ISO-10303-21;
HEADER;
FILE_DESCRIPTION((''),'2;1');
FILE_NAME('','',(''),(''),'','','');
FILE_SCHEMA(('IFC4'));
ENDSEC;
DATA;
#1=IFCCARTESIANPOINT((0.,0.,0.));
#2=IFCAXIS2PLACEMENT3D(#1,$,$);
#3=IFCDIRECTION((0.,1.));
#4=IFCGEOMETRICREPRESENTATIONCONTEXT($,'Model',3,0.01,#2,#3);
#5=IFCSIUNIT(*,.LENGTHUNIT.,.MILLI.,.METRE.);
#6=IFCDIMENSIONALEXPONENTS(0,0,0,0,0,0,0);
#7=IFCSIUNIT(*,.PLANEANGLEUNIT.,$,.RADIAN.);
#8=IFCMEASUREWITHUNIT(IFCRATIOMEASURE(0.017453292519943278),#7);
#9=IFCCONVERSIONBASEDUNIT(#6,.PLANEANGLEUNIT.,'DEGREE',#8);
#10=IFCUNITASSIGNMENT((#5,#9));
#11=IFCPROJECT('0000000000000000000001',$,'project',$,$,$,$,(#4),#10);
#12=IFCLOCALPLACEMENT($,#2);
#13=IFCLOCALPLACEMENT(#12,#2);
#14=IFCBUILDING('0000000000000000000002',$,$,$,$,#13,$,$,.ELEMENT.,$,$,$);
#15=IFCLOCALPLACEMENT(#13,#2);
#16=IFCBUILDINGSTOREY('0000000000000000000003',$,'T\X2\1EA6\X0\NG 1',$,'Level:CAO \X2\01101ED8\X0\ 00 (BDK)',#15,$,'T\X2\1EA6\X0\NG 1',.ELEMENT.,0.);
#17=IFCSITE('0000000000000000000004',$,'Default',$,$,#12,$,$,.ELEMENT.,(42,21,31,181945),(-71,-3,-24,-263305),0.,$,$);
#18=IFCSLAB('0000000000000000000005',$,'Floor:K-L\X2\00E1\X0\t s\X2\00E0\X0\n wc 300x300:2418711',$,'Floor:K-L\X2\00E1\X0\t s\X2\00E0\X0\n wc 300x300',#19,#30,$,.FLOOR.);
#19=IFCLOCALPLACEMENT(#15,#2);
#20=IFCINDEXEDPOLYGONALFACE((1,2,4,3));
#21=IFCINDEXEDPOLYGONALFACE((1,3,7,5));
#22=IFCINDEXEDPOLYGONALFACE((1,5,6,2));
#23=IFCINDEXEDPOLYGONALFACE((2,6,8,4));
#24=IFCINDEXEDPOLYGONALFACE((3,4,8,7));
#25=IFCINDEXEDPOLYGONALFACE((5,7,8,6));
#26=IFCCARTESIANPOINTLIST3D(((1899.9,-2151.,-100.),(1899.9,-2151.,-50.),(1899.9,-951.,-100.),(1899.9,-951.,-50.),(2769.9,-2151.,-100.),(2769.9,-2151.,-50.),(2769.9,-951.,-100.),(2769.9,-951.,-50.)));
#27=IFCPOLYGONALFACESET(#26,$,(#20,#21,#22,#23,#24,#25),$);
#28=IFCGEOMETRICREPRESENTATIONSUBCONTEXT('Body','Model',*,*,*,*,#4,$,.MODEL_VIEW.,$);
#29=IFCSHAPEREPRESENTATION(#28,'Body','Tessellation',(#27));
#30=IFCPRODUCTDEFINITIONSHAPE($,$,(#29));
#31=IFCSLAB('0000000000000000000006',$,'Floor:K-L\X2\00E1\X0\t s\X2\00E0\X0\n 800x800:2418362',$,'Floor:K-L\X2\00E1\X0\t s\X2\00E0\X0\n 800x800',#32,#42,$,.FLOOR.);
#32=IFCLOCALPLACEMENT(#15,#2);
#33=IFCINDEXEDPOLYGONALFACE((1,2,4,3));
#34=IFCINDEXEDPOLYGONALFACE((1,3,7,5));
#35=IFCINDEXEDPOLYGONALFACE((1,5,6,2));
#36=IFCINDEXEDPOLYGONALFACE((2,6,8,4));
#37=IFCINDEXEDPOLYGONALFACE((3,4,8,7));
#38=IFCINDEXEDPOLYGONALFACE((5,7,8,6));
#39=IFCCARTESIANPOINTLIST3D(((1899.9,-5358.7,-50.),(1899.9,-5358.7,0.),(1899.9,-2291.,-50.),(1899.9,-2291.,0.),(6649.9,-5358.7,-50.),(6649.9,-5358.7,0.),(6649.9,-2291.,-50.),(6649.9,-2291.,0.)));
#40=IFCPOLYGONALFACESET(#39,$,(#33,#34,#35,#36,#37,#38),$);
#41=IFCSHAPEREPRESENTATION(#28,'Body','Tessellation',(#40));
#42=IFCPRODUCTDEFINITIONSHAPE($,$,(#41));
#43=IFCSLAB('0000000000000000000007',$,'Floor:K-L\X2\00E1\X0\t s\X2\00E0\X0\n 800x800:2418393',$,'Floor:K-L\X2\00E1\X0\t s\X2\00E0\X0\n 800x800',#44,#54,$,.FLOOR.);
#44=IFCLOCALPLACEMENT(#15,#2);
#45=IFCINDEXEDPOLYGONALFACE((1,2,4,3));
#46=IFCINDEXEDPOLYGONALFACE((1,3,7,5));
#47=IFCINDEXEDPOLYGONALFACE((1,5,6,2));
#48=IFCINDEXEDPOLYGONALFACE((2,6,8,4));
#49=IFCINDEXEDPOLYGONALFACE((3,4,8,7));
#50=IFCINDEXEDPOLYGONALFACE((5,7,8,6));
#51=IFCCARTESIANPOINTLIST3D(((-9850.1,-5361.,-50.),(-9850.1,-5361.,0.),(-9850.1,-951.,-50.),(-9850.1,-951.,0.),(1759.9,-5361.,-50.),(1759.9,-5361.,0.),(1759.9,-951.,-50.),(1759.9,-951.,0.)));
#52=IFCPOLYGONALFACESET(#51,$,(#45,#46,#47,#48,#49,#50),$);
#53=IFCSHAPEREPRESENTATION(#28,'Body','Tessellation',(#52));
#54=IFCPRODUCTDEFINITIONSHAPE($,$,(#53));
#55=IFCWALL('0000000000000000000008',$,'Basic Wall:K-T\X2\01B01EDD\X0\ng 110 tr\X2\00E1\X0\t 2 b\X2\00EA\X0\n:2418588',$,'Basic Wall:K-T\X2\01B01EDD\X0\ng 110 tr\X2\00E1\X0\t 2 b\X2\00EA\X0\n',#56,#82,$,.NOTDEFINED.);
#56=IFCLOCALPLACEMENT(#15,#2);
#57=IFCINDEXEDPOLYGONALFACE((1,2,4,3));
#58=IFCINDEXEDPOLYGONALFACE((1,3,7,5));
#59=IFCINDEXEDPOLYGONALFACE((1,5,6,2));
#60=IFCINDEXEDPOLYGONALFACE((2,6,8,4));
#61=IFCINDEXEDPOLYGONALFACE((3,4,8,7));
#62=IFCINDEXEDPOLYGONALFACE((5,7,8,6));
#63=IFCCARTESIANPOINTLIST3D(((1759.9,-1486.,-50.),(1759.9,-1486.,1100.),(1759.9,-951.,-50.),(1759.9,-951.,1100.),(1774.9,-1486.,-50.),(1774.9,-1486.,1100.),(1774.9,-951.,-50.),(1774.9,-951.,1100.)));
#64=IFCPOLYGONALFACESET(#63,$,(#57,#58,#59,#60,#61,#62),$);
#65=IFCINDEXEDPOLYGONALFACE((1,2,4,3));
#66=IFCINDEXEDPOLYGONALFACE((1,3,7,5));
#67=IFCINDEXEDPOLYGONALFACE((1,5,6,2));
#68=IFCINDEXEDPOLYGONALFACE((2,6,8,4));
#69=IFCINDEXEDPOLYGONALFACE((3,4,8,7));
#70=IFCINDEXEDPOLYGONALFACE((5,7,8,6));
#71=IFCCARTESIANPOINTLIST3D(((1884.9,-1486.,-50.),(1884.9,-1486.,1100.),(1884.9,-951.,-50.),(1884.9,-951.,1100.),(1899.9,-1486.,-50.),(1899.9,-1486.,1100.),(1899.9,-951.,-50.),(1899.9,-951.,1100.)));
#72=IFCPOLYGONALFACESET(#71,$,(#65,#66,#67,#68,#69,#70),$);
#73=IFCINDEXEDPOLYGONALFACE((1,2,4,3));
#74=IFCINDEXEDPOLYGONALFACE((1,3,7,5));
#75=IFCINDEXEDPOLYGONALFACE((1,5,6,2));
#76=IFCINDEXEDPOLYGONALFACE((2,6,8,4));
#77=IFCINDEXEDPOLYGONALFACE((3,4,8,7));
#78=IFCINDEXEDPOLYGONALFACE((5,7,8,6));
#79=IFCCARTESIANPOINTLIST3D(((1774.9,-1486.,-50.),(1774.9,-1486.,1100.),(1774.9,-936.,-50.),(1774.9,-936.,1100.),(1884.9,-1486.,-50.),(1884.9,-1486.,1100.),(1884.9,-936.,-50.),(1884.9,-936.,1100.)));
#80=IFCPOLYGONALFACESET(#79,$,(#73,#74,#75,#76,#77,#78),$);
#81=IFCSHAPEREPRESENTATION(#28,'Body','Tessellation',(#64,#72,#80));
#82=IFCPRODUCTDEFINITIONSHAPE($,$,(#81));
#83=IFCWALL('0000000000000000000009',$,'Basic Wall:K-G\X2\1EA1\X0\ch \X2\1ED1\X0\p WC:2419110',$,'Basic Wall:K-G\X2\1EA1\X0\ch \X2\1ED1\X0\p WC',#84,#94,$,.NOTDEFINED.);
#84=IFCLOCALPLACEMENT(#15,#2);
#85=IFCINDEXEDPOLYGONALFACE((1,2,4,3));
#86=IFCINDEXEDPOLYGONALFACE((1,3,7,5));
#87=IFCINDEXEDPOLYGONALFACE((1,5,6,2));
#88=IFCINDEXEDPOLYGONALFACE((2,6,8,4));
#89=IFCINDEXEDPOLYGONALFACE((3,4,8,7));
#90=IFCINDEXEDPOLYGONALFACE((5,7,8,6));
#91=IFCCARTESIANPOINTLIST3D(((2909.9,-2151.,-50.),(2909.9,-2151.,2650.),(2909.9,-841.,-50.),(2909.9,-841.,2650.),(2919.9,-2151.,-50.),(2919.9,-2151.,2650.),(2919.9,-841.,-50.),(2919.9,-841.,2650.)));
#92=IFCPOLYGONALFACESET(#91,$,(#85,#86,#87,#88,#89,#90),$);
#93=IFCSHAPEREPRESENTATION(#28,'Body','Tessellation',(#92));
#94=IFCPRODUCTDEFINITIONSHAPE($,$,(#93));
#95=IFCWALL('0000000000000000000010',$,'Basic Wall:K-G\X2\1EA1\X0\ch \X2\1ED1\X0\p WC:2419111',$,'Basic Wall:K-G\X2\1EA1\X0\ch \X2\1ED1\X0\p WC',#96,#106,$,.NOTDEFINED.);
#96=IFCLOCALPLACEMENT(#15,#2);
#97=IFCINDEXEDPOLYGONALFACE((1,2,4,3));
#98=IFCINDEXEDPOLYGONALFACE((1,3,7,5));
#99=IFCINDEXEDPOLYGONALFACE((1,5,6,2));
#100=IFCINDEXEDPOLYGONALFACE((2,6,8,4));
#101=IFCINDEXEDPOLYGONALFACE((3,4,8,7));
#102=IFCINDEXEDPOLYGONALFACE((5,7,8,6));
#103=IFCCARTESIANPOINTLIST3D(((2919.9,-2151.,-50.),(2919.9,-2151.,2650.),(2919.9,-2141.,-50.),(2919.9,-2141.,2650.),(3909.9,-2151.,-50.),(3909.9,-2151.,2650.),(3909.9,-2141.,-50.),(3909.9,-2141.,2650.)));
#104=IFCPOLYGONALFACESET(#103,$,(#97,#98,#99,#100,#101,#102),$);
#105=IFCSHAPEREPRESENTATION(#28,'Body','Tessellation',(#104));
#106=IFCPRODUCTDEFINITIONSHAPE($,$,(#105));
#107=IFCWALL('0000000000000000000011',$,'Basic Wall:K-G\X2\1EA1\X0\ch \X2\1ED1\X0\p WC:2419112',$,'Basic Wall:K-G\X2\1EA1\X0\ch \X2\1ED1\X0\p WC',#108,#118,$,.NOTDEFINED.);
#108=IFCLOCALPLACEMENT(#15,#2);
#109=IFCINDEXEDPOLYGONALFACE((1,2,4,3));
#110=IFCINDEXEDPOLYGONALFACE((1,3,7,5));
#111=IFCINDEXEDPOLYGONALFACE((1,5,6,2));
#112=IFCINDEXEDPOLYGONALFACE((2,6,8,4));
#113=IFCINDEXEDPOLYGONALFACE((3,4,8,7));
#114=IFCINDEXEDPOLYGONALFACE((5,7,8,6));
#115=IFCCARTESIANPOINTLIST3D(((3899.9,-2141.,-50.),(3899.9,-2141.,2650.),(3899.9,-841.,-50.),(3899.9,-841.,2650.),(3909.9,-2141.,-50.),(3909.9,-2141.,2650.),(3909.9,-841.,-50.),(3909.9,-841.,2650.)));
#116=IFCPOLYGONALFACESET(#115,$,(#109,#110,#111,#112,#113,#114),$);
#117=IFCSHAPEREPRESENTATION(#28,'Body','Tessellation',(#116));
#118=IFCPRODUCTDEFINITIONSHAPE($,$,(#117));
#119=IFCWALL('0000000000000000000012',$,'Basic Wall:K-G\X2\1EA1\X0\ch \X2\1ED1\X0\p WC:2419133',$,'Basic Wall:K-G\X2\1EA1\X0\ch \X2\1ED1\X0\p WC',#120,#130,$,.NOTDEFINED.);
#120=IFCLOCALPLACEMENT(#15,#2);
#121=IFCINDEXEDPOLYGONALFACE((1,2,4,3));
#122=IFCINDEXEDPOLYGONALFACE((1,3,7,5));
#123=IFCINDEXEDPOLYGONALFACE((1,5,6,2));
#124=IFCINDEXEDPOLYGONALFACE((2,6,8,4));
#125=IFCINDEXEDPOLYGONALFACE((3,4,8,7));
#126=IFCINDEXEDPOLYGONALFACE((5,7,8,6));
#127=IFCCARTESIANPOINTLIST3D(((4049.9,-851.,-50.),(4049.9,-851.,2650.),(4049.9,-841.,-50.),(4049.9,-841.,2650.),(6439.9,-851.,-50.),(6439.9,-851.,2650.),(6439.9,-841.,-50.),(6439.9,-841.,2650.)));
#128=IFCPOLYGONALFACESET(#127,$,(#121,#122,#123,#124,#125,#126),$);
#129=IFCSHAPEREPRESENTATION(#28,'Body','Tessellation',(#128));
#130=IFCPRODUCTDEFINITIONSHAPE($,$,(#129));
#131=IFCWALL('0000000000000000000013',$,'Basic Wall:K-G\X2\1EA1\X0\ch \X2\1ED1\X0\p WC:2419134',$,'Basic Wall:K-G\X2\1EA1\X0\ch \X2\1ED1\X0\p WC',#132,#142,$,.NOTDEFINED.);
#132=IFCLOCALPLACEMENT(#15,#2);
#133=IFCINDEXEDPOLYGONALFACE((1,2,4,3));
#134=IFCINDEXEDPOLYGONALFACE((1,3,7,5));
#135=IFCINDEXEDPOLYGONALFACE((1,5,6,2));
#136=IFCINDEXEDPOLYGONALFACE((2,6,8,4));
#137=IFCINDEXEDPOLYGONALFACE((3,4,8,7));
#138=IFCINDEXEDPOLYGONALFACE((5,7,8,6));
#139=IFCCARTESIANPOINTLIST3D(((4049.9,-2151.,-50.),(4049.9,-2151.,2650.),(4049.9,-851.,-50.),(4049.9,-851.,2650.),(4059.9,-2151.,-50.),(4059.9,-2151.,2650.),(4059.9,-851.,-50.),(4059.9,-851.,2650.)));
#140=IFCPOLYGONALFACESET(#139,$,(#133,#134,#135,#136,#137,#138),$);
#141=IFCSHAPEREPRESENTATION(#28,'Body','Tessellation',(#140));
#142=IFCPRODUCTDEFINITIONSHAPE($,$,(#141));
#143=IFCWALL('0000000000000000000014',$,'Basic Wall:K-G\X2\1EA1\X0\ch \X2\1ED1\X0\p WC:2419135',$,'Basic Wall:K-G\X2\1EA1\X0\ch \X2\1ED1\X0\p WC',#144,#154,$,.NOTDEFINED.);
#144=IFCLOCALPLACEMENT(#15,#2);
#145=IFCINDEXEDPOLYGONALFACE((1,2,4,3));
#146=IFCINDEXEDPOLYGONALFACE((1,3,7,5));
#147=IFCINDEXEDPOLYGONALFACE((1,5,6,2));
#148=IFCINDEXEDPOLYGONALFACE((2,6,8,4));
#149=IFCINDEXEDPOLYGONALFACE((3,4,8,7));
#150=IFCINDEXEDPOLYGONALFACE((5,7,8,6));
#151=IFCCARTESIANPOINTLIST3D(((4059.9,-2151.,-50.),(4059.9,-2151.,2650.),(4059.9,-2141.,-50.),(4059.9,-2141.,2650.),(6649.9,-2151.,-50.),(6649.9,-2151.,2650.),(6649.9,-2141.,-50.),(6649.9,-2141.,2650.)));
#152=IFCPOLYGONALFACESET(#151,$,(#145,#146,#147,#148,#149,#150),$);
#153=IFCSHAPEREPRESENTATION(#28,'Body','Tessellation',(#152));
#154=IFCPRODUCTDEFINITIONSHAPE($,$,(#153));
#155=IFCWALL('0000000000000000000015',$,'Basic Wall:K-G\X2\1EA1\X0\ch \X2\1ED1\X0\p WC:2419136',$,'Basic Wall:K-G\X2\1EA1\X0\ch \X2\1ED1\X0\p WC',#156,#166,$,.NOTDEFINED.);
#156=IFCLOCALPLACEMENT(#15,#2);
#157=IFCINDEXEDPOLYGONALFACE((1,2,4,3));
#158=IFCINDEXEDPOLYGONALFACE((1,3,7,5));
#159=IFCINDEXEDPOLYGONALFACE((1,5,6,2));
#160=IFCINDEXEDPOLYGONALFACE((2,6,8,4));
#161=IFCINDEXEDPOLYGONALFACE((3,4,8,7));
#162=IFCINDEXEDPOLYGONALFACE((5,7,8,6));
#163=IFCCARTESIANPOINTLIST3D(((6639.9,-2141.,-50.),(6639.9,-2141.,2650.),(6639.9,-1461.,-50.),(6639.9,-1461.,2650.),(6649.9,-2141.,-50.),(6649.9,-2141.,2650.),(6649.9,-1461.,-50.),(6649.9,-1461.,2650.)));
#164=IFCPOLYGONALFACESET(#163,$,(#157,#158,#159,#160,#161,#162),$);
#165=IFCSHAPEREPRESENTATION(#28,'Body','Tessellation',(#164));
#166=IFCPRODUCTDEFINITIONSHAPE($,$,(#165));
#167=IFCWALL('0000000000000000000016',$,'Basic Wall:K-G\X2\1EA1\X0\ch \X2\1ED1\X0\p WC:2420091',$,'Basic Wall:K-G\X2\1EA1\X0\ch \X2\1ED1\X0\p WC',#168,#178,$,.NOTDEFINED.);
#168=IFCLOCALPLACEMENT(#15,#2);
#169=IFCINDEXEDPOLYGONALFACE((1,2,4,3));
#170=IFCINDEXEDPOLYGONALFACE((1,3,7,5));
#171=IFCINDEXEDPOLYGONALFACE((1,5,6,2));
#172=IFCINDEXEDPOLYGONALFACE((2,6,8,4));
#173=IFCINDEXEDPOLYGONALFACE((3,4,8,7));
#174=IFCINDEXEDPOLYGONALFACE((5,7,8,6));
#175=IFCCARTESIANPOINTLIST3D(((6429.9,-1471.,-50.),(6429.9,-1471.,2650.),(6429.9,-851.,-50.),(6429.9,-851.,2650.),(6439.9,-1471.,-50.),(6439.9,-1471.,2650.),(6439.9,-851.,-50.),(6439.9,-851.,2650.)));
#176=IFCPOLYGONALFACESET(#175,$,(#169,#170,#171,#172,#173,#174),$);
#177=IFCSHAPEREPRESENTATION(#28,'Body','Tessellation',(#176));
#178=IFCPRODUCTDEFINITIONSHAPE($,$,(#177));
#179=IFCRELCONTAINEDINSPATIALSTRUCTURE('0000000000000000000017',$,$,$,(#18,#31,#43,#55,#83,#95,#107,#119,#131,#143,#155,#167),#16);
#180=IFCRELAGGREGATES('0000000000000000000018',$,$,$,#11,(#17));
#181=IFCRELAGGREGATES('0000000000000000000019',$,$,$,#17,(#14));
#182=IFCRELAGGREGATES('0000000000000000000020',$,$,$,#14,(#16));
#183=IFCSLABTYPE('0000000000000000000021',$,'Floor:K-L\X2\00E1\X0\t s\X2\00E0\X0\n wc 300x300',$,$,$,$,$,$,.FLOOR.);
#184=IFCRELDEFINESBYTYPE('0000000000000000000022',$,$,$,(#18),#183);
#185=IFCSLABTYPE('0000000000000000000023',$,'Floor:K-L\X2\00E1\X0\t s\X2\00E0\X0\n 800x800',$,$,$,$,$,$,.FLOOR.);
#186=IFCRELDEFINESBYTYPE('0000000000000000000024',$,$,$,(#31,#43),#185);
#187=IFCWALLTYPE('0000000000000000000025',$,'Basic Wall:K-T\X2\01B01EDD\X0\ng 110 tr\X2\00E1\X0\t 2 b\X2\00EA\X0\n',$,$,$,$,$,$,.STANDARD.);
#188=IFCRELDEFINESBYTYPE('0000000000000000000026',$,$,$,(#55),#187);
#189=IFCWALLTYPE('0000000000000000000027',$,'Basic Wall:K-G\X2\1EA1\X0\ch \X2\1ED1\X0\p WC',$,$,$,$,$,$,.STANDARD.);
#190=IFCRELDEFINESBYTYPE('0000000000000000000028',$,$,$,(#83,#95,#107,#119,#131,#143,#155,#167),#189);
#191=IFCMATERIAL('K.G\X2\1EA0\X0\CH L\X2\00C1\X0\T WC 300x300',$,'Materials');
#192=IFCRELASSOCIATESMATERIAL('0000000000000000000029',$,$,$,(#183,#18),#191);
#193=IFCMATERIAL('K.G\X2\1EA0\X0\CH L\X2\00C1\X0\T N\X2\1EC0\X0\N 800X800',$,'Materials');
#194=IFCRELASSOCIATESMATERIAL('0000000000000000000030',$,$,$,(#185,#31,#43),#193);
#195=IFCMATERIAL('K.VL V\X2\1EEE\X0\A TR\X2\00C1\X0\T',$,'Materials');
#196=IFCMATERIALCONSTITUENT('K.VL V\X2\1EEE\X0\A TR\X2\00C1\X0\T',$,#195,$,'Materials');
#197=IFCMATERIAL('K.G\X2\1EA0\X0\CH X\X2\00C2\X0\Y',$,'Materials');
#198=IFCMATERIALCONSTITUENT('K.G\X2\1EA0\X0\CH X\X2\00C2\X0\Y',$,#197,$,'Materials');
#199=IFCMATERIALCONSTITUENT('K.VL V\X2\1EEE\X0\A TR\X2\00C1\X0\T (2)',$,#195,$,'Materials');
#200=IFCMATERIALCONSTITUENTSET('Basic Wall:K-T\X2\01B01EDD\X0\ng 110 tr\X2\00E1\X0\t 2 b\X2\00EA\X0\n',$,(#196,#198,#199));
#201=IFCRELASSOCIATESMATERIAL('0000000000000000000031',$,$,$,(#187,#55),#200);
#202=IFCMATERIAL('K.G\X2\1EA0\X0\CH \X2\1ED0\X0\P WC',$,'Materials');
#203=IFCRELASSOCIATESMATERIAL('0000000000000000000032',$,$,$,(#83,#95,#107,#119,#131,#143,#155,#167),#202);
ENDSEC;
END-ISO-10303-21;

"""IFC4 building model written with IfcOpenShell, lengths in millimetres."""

from ifc_helpers import new_model, entity, si_unit, converted_unit, direction, frame, origin, place, context, subcontext, project, spatial, indexed_curve, outline, extrude, material, constituent, constituent_set, type_object, element, save


model = new_model("IFC4")

# Units and contexts
model_context = context("Model", 3, precision=0.01, world=origin(), true_north=direction((0.0, 1.0)))
body_context = subcontext(model_context, "Body", "Model", "MODEL_VIEW")
ifc_project = project(units=[si_unit("LENGTHUNIT", "METRE", prefix="MILLI"), converted_unit("PLANEANGLEUNIT", "DEGREE", entity("IfcRatioMeasure", 0.017453292519943278), si_unit("PLANEANGLEUNIT", "RADIAN"), dimensions=[0, 0, 0, 0, 0, 0, 0])], contexts=[model_context])

# Site, building, storey
site_placement = place(None, origin())
site = spatial("IfcSite", under=ifc_project, at=site_placement, Name="Default", CompositionType="ELEMENT", RefLatitude=(42, 21, 31, 181945), RefLongitude=(-71, -3, -24, -263305), RefElevation=0.0)
building_placement = place(site_placement, origin())
building = spatial("IfcBuilding", under=site, at=building_placement, CompositionType="ELEMENT")
storey_placement = place(building_placement, origin())
storey = spatial("IfcBuildingStorey", under=building, at=storey_placement, Name="TẦNG 1", ObjectType="Level:CAO ĐỘ 00 (BDK)", LongName="TẦNG 1", CompositionType="ELEMENT", Elevation=0.0)

# Slabs
ifc_material_1 = material(Name="K.GẠCH LÁT WC 300x300", Category="Materials")
slab_type_1 = type_object("IfcSlabType", Name="Floor:K-Lát sàn wc 300x300", PredefinedType="FLOOR", material=ifc_material_1)
slab_1_placement = place(storey_placement, origin())
element("IfcSlab", 1, at=slab_1_placement, inside=storey, type_object=slab_type_1, material=ifc_material_1, Name="Floor:K-Lát sàn wc 300x300:2418711", ObjectType="Floor:K-Lát sàn wc 300x300", PredefinedType="FLOOR", context=body_context, shape_type="SweptSolid", body=[
    extrude(outline(indexed_curve([(-600.0, -435.0), (600.0, -435.0), (600.0, 435.0), (-600.0, 435.0), (-600.0, -435.0)], self_intersect=False)), frame((2334.9, -1551.0, -50.0), z_axis=(0.0, 0.0, -1.0), x_axis=(0.0, 1.0, 0.0)), (0.0, 0.0, 1.0), 50.0),
])
ifc_material_2 = material(Name="K.GẠCH LÁT NỀN 800X800", Category="Materials")
slab_type_2 = type_object("IfcSlabType", Name="Floor:K-Lát sàn 800x800", PredefinedType="FLOOR", material=ifc_material_2)
slab_2_placement = place(storey_placement, origin())
element("IfcSlab", 2, at=slab_2_placement, inside=storey, type_object=slab_type_2, material=ifc_material_2, Name="Floor:K-Lát sàn 800x800:2418362", ObjectType="Floor:K-Lát sàn 800x800", PredefinedType="FLOOR", context=body_context, shape_type="SweptSolid", body=[
    extrude(outline(indexed_curve([(-1533.8, -2375.0), (1533.8, -2375.0), (1533.8, 2375.0), (-1533.8, 2375.0), (-1533.8, -2375.0)], self_intersect=False)), frame((4274.9, -3824.8, 0.0), z_axis=(0.0, 0.0, -1.0), x_axis=(0.0, 1.0, 0.0)), (0.0, 0.0, 1.0), 50.0),
])
slab_3_placement = place(storey_placement, origin())
element("IfcSlab", 3, at=slab_3_placement, inside=storey, type_object=slab_type_2, material=ifc_material_2, Name="Floor:K-Lát sàn 800x800:2418393", ObjectType="Floor:K-Lát sàn 800x800", PredefinedType="FLOOR", context=body_context, shape_type="SweptSolid", body=[
    extrude(outline(indexed_curve([(-2205.0, -5805.0), (2205.0, -5805.0), (2205.0, 5805.0), (-2205.0, 5805.0), (-2205.0, -5805.0)], self_intersect=False)), frame((-4045.1, -3156.0, 0.0), z_axis=(0.0, 0.0, -1.0), x_axis=(0.0, 1.0, 0.0)), (0.0, 0.0, 1.0), 50.0),
])

# Shared definitions
ifc_material_3 = material(Name="K.VL VỮA TRÁT", Category="Materials")
ifc_constituent_1 = constituent(ifc_material_3, Name="K.VL VỮA TRÁT", Category="Materials")
ifc_material_4 = material(Name="K.GẠCH XÂY", Category="Materials")
ifc_constituent_2 = constituent(ifc_material_4, Name="K.GẠCH XÂY", Category="Materials")
ifc_constituent_3 = constituent(ifc_material_3, Name="K.VL VỮA TRÁT (2)", Category="Materials")
ifc_constituent_set_1 = constituent_set(constituents=[ifc_constituent_1, ifc_constituent_2, ifc_constituent_3], Name="Basic Wall:K-Tường 110 trát 2 bên")
wall_type_1 = type_object("IfcWallType", Name="Basic Wall:K-Tường 110 trát 2 bên", PredefinedType="STANDARD", material=ifc_constituent_set_1)

# Walls
wall_1_placement = place(storey_placement, frame((1829.9, -951.0, -50.0), z_axis=(0.0, 0.0, 1.0), x_axis=(0.0, -1.0, 0.0)))
element("IfcWall", 4, at=wall_1_placement, inside=storey, type_object=wall_type_1, material=ifc_constituent_set_1, Name="Basic Wall:K-Tường 110 trát 2 bên:2418588", ObjectType="Basic Wall:K-Tường 110 trát 2 bên", PredefinedType="NOTDEFINED", context=body_context, shape_type="SweptSolid", body=[
    extrude(outline(indexed_curve([(-7.5, -267.5), (7.5, -267.5), (7.5, 267.5), (-7.5, 267.5), (-7.5, -267.5)], self_intersect=False)), frame((267.5, -62.5, 0.0), z_axis=(0.0, 0.0, 1.0), x_axis=(0.0, 1.0, 0.0)), (0.0, 0.0, 1.0), 1150.0),
    extrude(outline(indexed_curve([(-7.5, -267.5), (7.5, -267.5), (7.5, 267.5), (-7.5, 267.5), (-7.5, -267.5)], self_intersect=False)), frame((267.5, 62.5, 0.0), z_axis=(0.0, 0.0, 1.0), x_axis=(0.0, -1.0, 0.0)), (0.0, 0.0, 1.0), 1150.0),
    extrude(outline(indexed_curve([(-275.0, -55.0), (275.0, -55.0), (275.0, 55.0), (-275.0, 55.0), (-275.0, -55.0)], self_intersect=False)), frame((260.0, 0.0, 0.0)), (0.0, 0.0, 1.0), 1150.0),
])
ifc_material_5 = material(Name="K.GẠCH ỐP WC", Category="Materials")
wall_type_2 = type_object("IfcWallType", Name="Basic Wall:K-Gạch ốp WC", PredefinedType="STANDARD")
wall_2_placement = place(storey_placement, frame((2914.9, -2151.0, -50.0), z_axis=(0.0, 0.0, 1.0), x_axis=(0.0, 1.0, 0.0)))
element("IfcWall", 5, at=wall_2_placement, inside=storey, type_object=wall_type_2, material=ifc_material_5, Name="Basic Wall:K-Gạch ốp WC:2419110", ObjectType="Basic Wall:K-Gạch ốp WC", PredefinedType="NOTDEFINED", context=body_context, shape_type="SweptSolid", body=[
    extrude(outline(indexed_curve([(1310.0, 5.0), (0.0, 5.0), (0.0, -5.0), (1310.0, -5.0), (1310.0, 5.0)], self_intersect=False)), origin(), (0.0, 0.0, 1.0), 2700.0),
])
wall_3_placement = place(storey_placement, frame((3909.9, -2146.0, -50.0), z_axis=(0.0, 0.0, 1.0), x_axis=(-1.0, 0.0, 0.0)))
element("IfcWall", 6, at=wall_3_placement, inside=storey, type_object=wall_type_2, material=ifc_material_5, Name="Basic Wall:K-Gạch ốp WC:2419111", ObjectType="Basic Wall:K-Gạch ốp WC", PredefinedType="NOTDEFINED", context=body_context, shape_type="SweptSolid", body=[
    extrude(outline(indexed_curve([(990.0, 5.0), (0.0, 5.0), (0.0, -5.0), (990.0, -5.0), (990.0, 5.0)], self_intersect=False)), origin(), (0.0, 0.0, 1.0), 2700.0),
])
wall_4_placement = place(storey_placement, frame((3904.9, -841.0, -50.0), z_axis=(0.0, 0.0, 1.0), x_axis=(0.0, -1.0, 0.0)))
element("IfcWall", 7, at=wall_4_placement, inside=storey, type_object=wall_type_2, material=ifc_material_5, Name="Basic Wall:K-Gạch ốp WC:2419112", ObjectType="Basic Wall:K-Gạch ốp WC", PredefinedType="NOTDEFINED", context=body_context, shape_type="SweptSolid", body=[
    extrude(outline(indexed_curve([(1300.0, 5.0), (0.0, 5.0), (0.0, -5.0), (1300.0, -5.0), (1300.0, 5.0)], self_intersect=False)), origin(), (0.0, 0.0, 1.0), 2700.0),
])
wall_5_placement = place(storey_placement, frame((4049.9, -846.0, -50.0)))
element("IfcWall", 8, at=wall_5_placement, inside=storey, type_object=wall_type_2, material=ifc_material_5, Name="Basic Wall:K-Gạch ốp WC:2419133", ObjectType="Basic Wall:K-Gạch ốp WC", PredefinedType="NOTDEFINED", context=body_context, shape_type="SweptSolid", body=[
    extrude(outline(indexed_curve([(2390.0, 5.0), (0.0, 5.0), (0.0, -5.0), (2390.0, -5.0), (2390.0, 5.0)], self_intersect=False)), origin(), (0.0, 0.0, 1.0), 2700.0),
])
wall_6_placement = place(storey_placement, frame((4054.9, -2151.0, -50.0), z_axis=(0.0, 0.0, 1.0), x_axis=(0.0, 1.0, 0.0)))
element("IfcWall", 9, at=wall_6_placement, inside=storey, type_object=wall_type_2, material=ifc_material_5, Name="Basic Wall:K-Gạch ốp WC:2419134", ObjectType="Basic Wall:K-Gạch ốp WC", PredefinedType="NOTDEFINED", context=body_context, shape_type="SweptSolid", body=[
    extrude(outline(indexed_curve([(1300.0, 5.0), (0.0, 5.0), (0.0, -5.0), (1300.0, -5.0), (1300.0, 5.0)], self_intersect=False)), origin(), (0.0, 0.0, 1.0), 2700.0),
])
wall_7_placement = place(storey_placement, frame((6649.9, -2146.0, -50.0), z_axis=(0.0, 0.0, 1.0), x_axis=(-1.0, 0.0, 0.0)))
element("IfcWall", 10, at=wall_7_placement, inside=storey, type_object=wall_type_2, material=ifc_material_5, Name="Basic Wall:K-Gạch ốp WC:2419135", ObjectType="Basic Wall:K-Gạch ốp WC", PredefinedType="NOTDEFINED", context=body_context, shape_type="SweptSolid", body=[
    extrude(outline(indexed_curve([(2590.0, 5.0), (0.0, 5.0), (0.0, -5.0), (2590.0, -5.0), (2590.0, 5.0)], self_intersect=False)), origin(), (0.0, 0.0, 1.0), 2700.0),
])
wall_8_placement = place(storey_placement, frame((6644.9, -1461.0, -50.0), z_axis=(0.0, 0.0, 1.0), x_axis=(0.0, -1.0, 0.0)))
element("IfcWall", 11, at=wall_8_placement, inside=storey, type_object=wall_type_2, material=ifc_material_5, Name="Basic Wall:K-Gạch ốp WC:2419136", ObjectType="Basic Wall:K-Gạch ốp WC", PredefinedType="NOTDEFINED", context=body_context, shape_type="SweptSolid", body=[
    extrude(outline(indexed_curve([(680.0, 5.0), (0.0, 5.0), (0.0, -5.0), (680.0, -5.0), (680.0, 5.0)], self_intersect=False)), origin(), (0.0, 0.0, 1.0), 2700.0),
])
wall_9_placement = place(storey_placement, frame((6434.9, -851.0, -50.0), z_axis=(0.0, 0.0, 1.0), x_axis=(0.0, -1.0, 0.0)))
element("IfcWall", 12, at=wall_9_placement, inside=storey, type_object=wall_type_2, material=ifc_material_5, Name="Basic Wall:K-Gạch ốp WC:2420091", ObjectType="Basic Wall:K-Gạch ốp WC", PredefinedType="NOTDEFINED", context=body_context, shape_type="SweptSolid", body=[
    extrude(outline(indexed_curve([(620.0, 5.0), (0.0, 5.0), (0.0, -5.0), (620.0, -5.0), (620.0, 5.0)], self_intersect=False)), origin(), (0.0, 0.0, 1.0), 2700.0),
])

save(model, "model.ifc")
